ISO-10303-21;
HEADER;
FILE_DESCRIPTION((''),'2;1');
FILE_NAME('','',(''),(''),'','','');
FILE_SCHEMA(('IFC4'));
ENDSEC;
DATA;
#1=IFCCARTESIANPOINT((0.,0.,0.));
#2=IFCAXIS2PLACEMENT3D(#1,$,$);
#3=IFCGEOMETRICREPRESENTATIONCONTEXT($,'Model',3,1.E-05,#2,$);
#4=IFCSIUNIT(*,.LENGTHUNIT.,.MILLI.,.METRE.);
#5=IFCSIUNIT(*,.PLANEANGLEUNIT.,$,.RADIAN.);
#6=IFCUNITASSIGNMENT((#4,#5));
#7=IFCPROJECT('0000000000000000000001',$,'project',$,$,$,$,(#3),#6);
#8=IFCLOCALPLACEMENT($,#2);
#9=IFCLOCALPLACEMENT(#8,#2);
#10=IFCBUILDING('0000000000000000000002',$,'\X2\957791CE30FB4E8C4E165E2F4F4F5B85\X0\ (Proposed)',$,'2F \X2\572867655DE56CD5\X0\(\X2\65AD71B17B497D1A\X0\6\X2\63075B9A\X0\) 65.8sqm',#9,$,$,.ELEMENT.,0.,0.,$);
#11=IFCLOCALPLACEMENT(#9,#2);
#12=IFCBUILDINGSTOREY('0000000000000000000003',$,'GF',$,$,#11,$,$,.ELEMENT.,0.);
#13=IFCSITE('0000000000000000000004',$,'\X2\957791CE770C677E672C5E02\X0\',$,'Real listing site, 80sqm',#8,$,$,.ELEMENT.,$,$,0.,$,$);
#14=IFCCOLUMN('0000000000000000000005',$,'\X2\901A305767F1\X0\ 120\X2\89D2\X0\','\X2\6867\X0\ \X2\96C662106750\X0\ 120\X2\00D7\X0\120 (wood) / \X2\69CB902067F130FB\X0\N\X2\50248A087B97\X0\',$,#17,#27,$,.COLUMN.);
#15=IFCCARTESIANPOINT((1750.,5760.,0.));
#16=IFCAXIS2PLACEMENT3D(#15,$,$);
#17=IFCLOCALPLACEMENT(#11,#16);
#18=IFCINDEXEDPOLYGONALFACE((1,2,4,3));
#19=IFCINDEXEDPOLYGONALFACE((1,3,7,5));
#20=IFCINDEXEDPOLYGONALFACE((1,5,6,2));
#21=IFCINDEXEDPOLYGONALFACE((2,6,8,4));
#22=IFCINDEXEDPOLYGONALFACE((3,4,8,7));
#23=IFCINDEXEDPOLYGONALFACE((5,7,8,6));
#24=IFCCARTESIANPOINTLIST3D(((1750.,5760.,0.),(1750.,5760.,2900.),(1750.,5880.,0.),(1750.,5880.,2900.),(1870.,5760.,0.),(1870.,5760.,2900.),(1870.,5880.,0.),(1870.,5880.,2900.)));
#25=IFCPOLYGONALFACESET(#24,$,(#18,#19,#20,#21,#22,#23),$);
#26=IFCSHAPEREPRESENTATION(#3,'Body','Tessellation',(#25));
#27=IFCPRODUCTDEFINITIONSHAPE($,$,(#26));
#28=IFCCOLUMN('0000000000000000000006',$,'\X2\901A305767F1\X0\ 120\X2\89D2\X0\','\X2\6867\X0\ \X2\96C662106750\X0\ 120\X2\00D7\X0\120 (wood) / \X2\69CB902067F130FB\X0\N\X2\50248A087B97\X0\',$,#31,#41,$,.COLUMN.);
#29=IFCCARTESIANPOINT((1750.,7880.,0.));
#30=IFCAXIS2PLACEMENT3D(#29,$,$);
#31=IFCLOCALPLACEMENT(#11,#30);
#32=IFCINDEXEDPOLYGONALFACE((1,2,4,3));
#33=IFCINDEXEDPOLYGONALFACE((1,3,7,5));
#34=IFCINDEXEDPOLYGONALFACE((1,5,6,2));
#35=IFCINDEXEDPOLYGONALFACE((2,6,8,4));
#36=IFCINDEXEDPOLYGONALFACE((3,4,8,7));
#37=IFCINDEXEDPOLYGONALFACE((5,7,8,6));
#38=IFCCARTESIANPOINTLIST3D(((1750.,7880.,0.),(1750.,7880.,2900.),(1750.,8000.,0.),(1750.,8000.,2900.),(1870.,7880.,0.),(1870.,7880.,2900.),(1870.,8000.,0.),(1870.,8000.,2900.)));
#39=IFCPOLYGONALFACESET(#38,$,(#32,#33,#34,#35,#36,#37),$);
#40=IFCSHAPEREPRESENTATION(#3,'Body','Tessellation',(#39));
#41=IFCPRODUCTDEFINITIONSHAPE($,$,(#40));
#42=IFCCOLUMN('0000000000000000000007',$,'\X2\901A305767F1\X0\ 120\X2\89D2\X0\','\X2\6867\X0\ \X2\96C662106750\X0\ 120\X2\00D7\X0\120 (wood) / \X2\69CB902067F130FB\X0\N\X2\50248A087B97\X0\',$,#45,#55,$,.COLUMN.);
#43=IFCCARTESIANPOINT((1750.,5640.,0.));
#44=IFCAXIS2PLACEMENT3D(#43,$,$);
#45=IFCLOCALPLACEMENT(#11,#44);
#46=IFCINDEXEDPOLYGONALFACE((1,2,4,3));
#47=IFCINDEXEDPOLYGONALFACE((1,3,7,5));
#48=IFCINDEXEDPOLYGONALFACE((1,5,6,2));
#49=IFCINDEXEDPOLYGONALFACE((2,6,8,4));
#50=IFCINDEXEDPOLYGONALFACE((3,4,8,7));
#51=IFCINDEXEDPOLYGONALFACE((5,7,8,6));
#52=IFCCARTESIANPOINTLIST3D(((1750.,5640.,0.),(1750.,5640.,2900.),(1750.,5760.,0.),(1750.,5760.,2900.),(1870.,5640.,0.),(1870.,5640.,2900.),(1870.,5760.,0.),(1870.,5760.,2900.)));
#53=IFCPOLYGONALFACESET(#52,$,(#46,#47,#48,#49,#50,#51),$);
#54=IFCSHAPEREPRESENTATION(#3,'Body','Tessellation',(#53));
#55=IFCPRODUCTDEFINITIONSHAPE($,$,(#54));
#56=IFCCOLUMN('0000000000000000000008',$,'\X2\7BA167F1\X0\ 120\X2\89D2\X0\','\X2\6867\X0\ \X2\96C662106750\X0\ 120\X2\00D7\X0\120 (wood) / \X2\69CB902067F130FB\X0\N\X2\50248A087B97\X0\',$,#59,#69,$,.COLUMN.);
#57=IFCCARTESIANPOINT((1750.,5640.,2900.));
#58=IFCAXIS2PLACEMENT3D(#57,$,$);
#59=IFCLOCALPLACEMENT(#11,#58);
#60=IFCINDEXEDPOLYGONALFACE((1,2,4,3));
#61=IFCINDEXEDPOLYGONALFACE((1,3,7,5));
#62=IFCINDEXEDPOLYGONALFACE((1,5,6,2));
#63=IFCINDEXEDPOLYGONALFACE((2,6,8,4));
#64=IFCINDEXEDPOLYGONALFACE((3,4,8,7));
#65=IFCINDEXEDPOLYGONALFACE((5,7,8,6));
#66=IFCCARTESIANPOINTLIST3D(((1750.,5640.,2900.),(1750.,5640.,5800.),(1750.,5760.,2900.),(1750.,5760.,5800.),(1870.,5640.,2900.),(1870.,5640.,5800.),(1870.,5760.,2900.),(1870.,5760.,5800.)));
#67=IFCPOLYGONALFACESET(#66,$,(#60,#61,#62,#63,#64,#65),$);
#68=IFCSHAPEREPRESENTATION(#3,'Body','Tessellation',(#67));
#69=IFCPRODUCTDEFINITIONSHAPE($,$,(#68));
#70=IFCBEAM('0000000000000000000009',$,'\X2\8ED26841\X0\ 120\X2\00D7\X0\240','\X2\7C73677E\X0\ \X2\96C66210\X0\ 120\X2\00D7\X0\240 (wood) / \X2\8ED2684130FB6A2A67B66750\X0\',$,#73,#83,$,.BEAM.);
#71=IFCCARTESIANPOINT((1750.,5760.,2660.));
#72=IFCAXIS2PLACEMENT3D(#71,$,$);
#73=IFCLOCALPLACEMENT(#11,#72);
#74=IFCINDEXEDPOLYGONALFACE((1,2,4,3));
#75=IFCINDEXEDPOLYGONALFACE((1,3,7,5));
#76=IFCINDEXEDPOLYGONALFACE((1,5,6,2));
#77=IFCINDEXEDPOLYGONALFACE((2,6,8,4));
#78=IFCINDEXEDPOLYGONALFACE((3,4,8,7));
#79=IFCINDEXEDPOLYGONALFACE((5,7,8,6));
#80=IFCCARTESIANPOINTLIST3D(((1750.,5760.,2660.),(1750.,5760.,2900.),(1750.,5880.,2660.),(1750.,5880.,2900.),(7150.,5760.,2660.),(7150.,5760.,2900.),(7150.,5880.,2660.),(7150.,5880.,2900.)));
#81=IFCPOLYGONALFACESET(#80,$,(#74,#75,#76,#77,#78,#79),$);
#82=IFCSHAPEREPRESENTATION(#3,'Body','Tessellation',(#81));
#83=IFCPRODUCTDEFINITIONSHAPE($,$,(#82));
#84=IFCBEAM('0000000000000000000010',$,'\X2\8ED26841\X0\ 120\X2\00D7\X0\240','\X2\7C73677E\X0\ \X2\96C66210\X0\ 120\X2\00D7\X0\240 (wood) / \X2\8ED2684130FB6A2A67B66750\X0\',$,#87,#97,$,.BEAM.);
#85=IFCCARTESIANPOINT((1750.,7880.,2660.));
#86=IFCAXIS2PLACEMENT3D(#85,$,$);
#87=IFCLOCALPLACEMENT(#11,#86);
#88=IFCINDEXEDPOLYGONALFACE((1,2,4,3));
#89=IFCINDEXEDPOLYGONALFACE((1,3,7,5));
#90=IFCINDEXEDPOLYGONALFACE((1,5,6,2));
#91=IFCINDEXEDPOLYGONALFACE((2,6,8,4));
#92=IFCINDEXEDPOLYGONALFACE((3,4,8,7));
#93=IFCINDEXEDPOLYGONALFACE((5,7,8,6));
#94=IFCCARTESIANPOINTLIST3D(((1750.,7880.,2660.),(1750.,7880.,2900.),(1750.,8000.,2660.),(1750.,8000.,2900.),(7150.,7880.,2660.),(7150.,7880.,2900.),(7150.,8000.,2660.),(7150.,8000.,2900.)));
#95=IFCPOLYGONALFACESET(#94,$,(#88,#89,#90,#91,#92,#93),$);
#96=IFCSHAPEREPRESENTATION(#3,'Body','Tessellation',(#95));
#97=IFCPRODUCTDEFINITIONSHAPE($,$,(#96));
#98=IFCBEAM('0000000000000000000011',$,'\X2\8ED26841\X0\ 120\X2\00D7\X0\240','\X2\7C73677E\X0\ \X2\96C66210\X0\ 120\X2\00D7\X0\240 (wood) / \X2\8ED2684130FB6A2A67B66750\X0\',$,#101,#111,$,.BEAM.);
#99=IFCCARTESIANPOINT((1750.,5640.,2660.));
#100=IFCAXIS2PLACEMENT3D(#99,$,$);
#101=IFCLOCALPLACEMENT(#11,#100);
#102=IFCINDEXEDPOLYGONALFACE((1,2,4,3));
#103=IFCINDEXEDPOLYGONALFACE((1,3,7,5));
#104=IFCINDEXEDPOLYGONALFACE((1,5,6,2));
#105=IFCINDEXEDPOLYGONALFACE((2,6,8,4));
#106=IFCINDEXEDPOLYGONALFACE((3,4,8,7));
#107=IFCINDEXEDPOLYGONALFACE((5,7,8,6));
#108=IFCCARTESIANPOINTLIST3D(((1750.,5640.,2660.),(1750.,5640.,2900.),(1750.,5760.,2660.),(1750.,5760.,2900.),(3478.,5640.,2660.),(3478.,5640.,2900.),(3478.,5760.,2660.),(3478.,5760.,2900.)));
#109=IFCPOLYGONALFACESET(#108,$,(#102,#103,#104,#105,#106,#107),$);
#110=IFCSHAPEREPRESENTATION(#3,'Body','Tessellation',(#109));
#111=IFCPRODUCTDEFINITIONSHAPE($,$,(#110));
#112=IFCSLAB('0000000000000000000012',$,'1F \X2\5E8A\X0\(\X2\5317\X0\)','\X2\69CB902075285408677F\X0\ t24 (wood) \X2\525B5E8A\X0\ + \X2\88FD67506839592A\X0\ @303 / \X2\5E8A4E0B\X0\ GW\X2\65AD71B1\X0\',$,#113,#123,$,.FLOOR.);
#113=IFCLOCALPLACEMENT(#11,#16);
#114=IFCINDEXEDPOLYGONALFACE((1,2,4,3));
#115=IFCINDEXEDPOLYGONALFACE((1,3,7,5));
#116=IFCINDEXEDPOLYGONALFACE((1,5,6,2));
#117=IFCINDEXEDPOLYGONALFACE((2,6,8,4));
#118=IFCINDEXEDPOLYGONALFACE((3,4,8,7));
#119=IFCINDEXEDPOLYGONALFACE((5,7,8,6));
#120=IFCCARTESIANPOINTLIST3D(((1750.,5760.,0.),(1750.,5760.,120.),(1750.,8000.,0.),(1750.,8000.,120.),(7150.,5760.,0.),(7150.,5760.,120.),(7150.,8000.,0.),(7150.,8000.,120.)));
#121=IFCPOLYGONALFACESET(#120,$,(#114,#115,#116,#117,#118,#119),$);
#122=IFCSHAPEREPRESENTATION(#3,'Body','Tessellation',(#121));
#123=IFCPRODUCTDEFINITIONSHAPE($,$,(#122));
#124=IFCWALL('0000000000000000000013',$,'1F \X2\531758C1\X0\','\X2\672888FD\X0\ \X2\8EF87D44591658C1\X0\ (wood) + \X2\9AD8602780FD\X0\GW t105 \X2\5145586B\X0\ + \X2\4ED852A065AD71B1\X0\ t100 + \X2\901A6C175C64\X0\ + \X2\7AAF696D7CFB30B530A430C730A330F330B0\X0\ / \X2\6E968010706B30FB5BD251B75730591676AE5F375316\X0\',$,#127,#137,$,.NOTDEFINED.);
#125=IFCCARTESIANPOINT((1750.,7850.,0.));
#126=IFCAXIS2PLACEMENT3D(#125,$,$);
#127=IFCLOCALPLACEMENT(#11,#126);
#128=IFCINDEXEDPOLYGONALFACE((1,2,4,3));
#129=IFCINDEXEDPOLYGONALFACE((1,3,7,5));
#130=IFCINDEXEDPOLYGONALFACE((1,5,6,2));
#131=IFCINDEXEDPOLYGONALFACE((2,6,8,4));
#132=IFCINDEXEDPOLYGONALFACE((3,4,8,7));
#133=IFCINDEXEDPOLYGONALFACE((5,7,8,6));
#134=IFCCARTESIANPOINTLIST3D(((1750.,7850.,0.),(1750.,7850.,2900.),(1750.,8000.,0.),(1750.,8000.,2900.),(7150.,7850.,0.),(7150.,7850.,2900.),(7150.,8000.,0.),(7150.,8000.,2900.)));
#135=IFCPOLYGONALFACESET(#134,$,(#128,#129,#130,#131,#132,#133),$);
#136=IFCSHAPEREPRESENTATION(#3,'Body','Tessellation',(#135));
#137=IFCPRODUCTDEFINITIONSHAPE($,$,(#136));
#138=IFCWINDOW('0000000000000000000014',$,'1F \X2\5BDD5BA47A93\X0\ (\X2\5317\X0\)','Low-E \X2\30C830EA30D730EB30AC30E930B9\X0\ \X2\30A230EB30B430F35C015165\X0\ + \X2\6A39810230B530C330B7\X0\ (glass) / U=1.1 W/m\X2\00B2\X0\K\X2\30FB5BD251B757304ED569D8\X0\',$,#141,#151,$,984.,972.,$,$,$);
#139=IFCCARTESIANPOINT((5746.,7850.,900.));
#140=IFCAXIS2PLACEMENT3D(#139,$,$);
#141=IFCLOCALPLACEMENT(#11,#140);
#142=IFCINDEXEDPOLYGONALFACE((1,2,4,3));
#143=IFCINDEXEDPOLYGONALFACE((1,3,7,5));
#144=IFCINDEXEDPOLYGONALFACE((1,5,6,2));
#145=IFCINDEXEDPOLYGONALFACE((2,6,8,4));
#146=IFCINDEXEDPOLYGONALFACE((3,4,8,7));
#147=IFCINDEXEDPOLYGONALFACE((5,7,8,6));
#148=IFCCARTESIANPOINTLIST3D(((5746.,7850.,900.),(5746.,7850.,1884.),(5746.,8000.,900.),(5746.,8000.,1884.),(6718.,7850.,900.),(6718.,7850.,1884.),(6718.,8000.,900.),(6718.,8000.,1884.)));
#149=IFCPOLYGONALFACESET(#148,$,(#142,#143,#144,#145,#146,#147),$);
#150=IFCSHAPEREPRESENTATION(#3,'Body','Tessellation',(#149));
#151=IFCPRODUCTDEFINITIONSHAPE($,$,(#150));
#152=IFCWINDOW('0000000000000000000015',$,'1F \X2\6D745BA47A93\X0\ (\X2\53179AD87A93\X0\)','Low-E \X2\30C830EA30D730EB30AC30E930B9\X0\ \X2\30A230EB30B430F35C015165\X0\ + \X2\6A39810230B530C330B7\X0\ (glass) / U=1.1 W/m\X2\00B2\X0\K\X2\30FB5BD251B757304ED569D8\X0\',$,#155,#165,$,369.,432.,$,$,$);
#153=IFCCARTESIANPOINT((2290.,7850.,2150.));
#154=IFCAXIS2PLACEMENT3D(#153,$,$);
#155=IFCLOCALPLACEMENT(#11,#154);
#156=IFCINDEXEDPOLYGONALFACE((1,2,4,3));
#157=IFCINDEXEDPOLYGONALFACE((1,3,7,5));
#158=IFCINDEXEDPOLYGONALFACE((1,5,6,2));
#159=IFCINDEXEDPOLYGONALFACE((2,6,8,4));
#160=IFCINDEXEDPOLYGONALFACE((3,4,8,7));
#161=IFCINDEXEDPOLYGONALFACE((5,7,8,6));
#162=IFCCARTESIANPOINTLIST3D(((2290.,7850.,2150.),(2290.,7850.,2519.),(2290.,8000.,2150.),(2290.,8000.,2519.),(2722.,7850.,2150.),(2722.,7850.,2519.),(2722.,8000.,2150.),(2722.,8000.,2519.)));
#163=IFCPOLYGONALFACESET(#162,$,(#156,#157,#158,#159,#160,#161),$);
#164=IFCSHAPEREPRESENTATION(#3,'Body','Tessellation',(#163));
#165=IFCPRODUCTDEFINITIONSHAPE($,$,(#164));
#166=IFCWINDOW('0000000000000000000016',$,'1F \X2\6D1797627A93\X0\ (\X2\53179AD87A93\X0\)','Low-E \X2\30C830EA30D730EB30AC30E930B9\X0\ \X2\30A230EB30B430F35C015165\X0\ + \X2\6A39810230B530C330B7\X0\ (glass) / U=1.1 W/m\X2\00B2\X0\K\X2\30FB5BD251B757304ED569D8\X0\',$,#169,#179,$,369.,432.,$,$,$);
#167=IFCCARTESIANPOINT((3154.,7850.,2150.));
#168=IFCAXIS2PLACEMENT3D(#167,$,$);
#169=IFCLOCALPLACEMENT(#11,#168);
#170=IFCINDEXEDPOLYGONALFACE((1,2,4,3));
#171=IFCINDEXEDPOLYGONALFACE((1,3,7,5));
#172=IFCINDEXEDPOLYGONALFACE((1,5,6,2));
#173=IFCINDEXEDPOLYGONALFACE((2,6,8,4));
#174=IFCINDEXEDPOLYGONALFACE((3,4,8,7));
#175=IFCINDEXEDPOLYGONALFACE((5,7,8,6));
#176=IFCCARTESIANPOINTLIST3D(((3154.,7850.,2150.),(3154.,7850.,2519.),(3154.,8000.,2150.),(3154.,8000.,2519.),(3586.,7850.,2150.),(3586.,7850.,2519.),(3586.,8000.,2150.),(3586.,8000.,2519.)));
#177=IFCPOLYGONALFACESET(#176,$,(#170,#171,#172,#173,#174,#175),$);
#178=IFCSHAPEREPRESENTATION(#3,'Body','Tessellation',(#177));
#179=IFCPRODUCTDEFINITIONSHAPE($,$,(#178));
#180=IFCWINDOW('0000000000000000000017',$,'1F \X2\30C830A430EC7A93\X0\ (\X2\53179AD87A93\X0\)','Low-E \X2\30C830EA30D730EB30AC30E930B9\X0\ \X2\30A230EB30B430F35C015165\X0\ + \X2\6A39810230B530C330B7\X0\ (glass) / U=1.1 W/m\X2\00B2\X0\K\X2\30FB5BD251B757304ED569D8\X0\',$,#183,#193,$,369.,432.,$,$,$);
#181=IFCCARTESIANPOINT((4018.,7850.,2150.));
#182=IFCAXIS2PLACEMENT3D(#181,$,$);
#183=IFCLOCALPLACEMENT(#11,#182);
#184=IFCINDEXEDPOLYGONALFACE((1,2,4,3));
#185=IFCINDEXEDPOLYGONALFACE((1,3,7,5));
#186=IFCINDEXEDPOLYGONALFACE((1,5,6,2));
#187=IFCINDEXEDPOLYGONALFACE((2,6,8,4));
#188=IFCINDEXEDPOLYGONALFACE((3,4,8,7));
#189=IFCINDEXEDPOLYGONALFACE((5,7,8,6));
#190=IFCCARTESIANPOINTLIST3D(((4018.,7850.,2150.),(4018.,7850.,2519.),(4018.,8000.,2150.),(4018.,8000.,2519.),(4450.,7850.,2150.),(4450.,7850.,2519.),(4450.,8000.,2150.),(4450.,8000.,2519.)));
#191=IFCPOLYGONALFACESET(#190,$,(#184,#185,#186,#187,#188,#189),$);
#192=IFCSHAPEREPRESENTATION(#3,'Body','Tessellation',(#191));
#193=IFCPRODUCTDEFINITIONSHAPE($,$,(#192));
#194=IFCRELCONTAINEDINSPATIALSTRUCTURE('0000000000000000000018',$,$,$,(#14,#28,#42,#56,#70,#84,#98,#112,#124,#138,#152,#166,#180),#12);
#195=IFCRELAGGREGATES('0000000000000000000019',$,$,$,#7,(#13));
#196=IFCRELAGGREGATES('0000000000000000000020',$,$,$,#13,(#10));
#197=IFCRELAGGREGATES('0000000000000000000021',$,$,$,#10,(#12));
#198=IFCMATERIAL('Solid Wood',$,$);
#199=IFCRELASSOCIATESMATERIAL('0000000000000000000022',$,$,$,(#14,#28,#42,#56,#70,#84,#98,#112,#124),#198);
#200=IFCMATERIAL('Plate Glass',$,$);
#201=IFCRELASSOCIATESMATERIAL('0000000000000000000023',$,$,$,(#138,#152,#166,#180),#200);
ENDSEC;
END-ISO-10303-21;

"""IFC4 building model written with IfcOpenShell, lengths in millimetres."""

from ifc_helpers import new_model, si_unit, frame, frame_2d, origin, place, context, project, spatial, rectangle, extrude, material, element, fill, save


model = new_model("IFC4")

# Units and contexts
model_context = context("Model", 3, precision=1e-05, world=origin())
ifc_project = project(units=[si_unit("LENGTHUNIT", "METRE", prefix="MILLI"), si_unit("PLANEANGLEUNIT", "RADIAN")], contexts=[model_context])

# Site, building, storey
site_placement = place(None, origin())
site = spatial("IfcSite", under=ifc_project, at=site_placement, Name="長野県松本市", ObjectType="Real listing site, 80sqm", CompositionType="ELEMENT", RefElevation=0.0)
building_placement = place(site_placement, origin())
building = spatial("IfcBuilding", under=site, at=building_placement, Name="長野・二世帯住宅 (Proposed)", ObjectType="2F 在来工法(断熱等級6指定) 65.8sqm", CompositionType="ELEMENT", ElevationOfRefHeight=0.0, ElevationOfTerrain=0.0)
storey_placement = place(building_placement, origin())
storey = spatial("IfcBuildingStorey", under=building, at=storey_placement, Name="GF", CompositionType="ELEMENT", Elevation=0.0)

# Columns
ifc_material_1 = material(Name="Solid Wood")
column_1_placement = place(storey_placement, frame((1750.0, 5760.0, 0.0)))
element("IfcColumn", 1, at=column_1_placement, inside=storey, material=ifc_material_1, Name="通し柱 120角", Description="桧 集成材 120×120 (wood) / 構造柱・N値計算", PredefinedType="COLUMN", context=model_context, shape_type="SweptSolid", body=[
    extrude(rectangle(XDim=120.0, YDim=120.0, at=frame_2d((60.0, 60.0))), frame((1750.0, 5760.0, 0.0)), (0.0, 0.0, 1.0), 2900.0),
])
column_2_placement = place(storey_placement, frame((1750.0, 7880.0, 0.0)))
element("IfcColumn", 2, at=column_2_placement, inside=storey, material=ifc_material_1, Name="通し柱 120角", Description="桧 集成材 120×120 (wood) / 構造柱・N値計算", PredefinedType="COLUMN", context=model_context, shape_type="SweptSolid", body=[
    extrude(rectangle(XDim=120.0, YDim=120.0, at=frame_2d((60.0, 60.0))), frame((1750.0, 7880.0, 0.0)), (0.0, 0.0, 1.0), 2900.0),
])
column_3_placement = place(storey_placement, frame((1750.0, 5640.0, 0.0)))
element("IfcColumn", 3, at=column_3_placement, inside=storey, material=ifc_material_1, Name="通し柱 120角", Description="桧 集成材 120×120 (wood) / 構造柱・N値計算", PredefinedType="COLUMN", context=model_context, shape_type="SweptSolid", body=[
    extrude(rectangle(XDim=120.0, YDim=120.0, at=frame_2d((60.0, 60.0))), frame((1750.0, 5640.0, 0.0)), (0.0, 0.0, 1.0), 2900.0),
])
column_4_placement = place(storey_placement, frame((1750.0, 5640.0, 2900.0)))
element("IfcColumn", 4, at=column_4_placement, inside=storey, material=ifc_material_1, Name="管柱 120角", Description="桧 集成材 120×120 (wood) / 構造柱・N値計算", PredefinedType="COLUMN", context=model_context, shape_type="SweptSolid", body=[
    extrude(rectangle(XDim=120.0, YDim=120.0, at=frame_2d((60.0, 60.0))), frame((1750.0, 5640.0, 2900.0)), (0.0, 0.0, 1.0), 2900.0),
])

# Beams
beam_1_placement = place(storey_placement, frame((1750.0, 5760.0, 2660.0)))
element("IfcBeam", 5, at=beam_1_placement, inside=storey, material=ifc_material_1, Name="軒桁 120×240", Description="米松 集成 120×240 (wood) / 軒桁・横架材", PredefinedType="BEAM", context=model_context, shape_type="SweptSolid", body=[
    extrude(rectangle(XDim=5400.0, YDim=120.0, at=frame_2d((2700.0, 60.0))), frame((1750.0, 5760.0, 2660.0)), (0.0, 0.0, 1.0), 240.0),
])
beam_2_placement = place(storey_placement, frame((1750.0, 7880.0, 2660.0)))
element("IfcBeam", 6, at=beam_2_placement, inside=storey, material=ifc_material_1, Name="軒桁 120×240", Description="米松 集成 120×240 (wood) / 軒桁・横架材", PredefinedType="BEAM", context=model_context, shape_type="SweptSolid", body=[
    extrude(rectangle(XDim=5400.0, YDim=120.0, at=frame_2d((2700.0, 60.0))), frame((1750.0, 7880.0, 2660.0)), (0.0, 0.0, 1.0), 240.0),
])
beam_3_placement = place(storey_placement, frame((1750.0, 5640.0, 2660.0)))
element("IfcBeam", 7, at=beam_3_placement, inside=storey, material=ifc_material_1, Name="軒桁 120×240", Description="米松 集成 120×240 (wood) / 軒桁・横架材", PredefinedType="BEAM", context=model_context, shape_type="SweptSolid", body=[
    extrude(rectangle(XDim=1728.0, YDim=120.0, at=frame_2d((864.0, 60.0))), frame((1750.0, 5640.0, 2660.0)), (0.0, 0.0, 1.0), 240.0),
])

# Slab
slab_placement = place(storey_placement, frame((1750.0, 5760.0, 0.0)))
element("IfcSlab", 8, at=slab_placement, inside=storey, material=ifc_material_1, Name="1F 床(北)", Description="構造用合板 t24 (wood) 剛床 + 製材根太 @303 / 床下 GW断熱", PredefinedType="FLOOR", context=model_context, shape_type="SweptSolid", body=[
    extrude(rectangle(XDim=5400.0, YDim=2240.0, at=frame_2d((2700.0, 1120.0))), frame((1750.0, 5760.0, 0.0)), (0.0, 0.0, 1.0), 120.0),
])

# Wall, openings, windows
wall_1_placement = place(storey_placement, frame((1750.0, 7850.0, 0.0)))
wall_1 = element("IfcWall", 9, at=wall_1_placement, inside=storey, material=ifc_material_1, Name="1F 北壁", Description="木製 軸組外壁 (wood) + 高性能GW t105 充填 + 付加断熱 t100 + 通気層 + 窯業系サイディング / 準耐火・寒冷地外皮強化", PredefinedType="NOTDEFINED", context=model_context, shape_type="SweptSolid", body=[
    extrude(rectangle(XDim=5400.0, YDim=150.0, at=frame_2d((2700.0, 75.0))), frame((1750.0, 7850.0, 0.0)), (0.0, 0.0, 1.0), 2900.0),
])
opening_1_placement = place(storey_placement, frame((5746.0, 7850.0, 900.0)))
opening_1 = element("IfcOpeningElement", 10, at=opening_1_placement, cuts=wall_1, PredefinedType="NOTDEFINED", context=model_context, shape_type="SweptSolid", body=[
    extrude(rectangle(XDim=972.0, YDim=150.0, at=frame_2d((486.0, 75.0))), frame((5746.0, 7850.0, 900.0)), (0.0, 0.0, 1.0), 984.0),
])
opening_2_placement = place(storey_placement, frame((2290.0, 7850.0, 2150.0)))
opening_2 = element("IfcOpeningElement", 11, at=opening_2_placement, cuts=wall_1, PredefinedType="NOTDEFINED", context=model_context, shape_type="SweptSolid", body=[
    extrude(rectangle(XDim=432.0, YDim=150.0, at=frame_2d((216.0, 75.0))), frame((2290.0, 7850.0, 2150.0)), (0.0, 0.0, 1.0), 369.0),
])
opening_3_placement = place(storey_placement, frame((3154.0, 7850.0, 2150.0)))
opening_3 = element("IfcOpeningElement", 12, at=opening_3_placement, cuts=wall_1, PredefinedType="NOTDEFINED", context=model_context, shape_type="SweptSolid", body=[
    extrude(rectangle(XDim=432.0, YDim=150.0, at=frame_2d((216.0, 75.0))), frame((3154.0, 7850.0, 2150.0)), (0.0, 0.0, 1.0), 369.0),
])
opening_4_placement = place(storey_placement, frame((4018.0, 7850.0, 2150.0)))
opening_4 = element("IfcOpeningElement", 13, at=opening_4_placement, cuts=wall_1, PredefinedType="NOTDEFINED", context=model_context, shape_type="SweptSolid", body=[
    extrude(rectangle(XDim=432.0, YDim=150.0, at=frame_2d((216.0, 75.0))), frame((4018.0, 7850.0, 2150.0)), (0.0, 0.0, 1.0), 369.0),
])
ifc_material_2 = material(Name="Plate Glass")
window_1_placement = place(storey_placement, frame((5746.0, 7850.0, 900.0)))
window_1 = element("IfcWindow", 14, at=window_1_placement, inside=storey, material=ifc_material_2, Name="1F 寝室窓 (北)", Description="Low-E トリプルガラス アルゴン封入 + 樹脂サッシ (glass) / U=1.1 W/m²K・寒冷地仕様", OverallHeight=984.0, OverallWidth=972.0, context=model_context, shape_type="SweptSolid", body=[
    extrude(rectangle(XDim=972.0, YDim=150.0, at=frame_2d((486.0, 75.0))), frame((5746.0, 7850.0, 900.0)), (0.0, 0.0, 1.0), 984.0),
])
fill(opening_1, window_1)
window_2_placement = place(storey_placement, frame((2290.0, 7850.0, 2150.0)))
window_2 = element("IfcWindow", 15, at=window_2_placement, inside=storey, material=ifc_material_2, Name="1F 浴室窓 (北高窓)", Description="Low-E トリプルガラス アルゴン封入 + 樹脂サッシ (glass) / U=1.1 W/m²K・寒冷地仕様", OverallHeight=369.0, OverallWidth=432.0, context=model_context, shape_type="SweptSolid", body=[
    extrude(rectangle(XDim=432.0, YDim=150.0, at=frame_2d((216.0, 75.0))), frame((2290.0, 7850.0, 2150.0)), (0.0, 0.0, 1.0), 369.0),
])
fill(opening_2, window_2)
window_3_placement = place(storey_placement, frame((3154.0, 7850.0, 2150.0)))
window_3 = element("IfcWindow", 16, at=window_3_placement, inside=storey, material=ifc_material_2, Name="1F 洗面窓 (北高窓)", Description="Low-E トリプルガラス アルゴン封入 + 樹脂サッシ (glass) / U=1.1 W/m²K・寒冷地仕様", OverallHeight=369.0, OverallWidth=432.0, context=model_context, shape_type="SweptSolid", body=[
    extrude(rectangle(XDim=432.0, YDim=150.0, at=frame_2d((216.0, 75.0))), frame((3154.0, 7850.0, 2150.0)), (0.0, 0.0, 1.0), 369.0),
])
fill(opening_3, window_3)
window_4_placement = place(storey_placement, frame((4018.0, 7850.0, 2150.0)))
window_4 = element("IfcWindow", 17, at=window_4_placement, inside=storey, material=ifc_material_2, Name="1F トイレ窓 (北高窓)", Description="Low-E トリプルガラス アルゴン封入 + 樹脂サッシ (glass) / U=1.1 W/m²K・寒冷地仕様", OverallHeight=369.0, OverallWidth=432.0, context=model_context, shape_type="SweptSolid", body=[
    extrude(rectangle(XDim=432.0, YDim=150.0, at=frame_2d((216.0, 75.0))), frame((4018.0, 7850.0, 2150.0)), (0.0, 0.0, 1.0), 369.0),
])
fill(opening_4, window_4)

save(model, "model.ifc")
